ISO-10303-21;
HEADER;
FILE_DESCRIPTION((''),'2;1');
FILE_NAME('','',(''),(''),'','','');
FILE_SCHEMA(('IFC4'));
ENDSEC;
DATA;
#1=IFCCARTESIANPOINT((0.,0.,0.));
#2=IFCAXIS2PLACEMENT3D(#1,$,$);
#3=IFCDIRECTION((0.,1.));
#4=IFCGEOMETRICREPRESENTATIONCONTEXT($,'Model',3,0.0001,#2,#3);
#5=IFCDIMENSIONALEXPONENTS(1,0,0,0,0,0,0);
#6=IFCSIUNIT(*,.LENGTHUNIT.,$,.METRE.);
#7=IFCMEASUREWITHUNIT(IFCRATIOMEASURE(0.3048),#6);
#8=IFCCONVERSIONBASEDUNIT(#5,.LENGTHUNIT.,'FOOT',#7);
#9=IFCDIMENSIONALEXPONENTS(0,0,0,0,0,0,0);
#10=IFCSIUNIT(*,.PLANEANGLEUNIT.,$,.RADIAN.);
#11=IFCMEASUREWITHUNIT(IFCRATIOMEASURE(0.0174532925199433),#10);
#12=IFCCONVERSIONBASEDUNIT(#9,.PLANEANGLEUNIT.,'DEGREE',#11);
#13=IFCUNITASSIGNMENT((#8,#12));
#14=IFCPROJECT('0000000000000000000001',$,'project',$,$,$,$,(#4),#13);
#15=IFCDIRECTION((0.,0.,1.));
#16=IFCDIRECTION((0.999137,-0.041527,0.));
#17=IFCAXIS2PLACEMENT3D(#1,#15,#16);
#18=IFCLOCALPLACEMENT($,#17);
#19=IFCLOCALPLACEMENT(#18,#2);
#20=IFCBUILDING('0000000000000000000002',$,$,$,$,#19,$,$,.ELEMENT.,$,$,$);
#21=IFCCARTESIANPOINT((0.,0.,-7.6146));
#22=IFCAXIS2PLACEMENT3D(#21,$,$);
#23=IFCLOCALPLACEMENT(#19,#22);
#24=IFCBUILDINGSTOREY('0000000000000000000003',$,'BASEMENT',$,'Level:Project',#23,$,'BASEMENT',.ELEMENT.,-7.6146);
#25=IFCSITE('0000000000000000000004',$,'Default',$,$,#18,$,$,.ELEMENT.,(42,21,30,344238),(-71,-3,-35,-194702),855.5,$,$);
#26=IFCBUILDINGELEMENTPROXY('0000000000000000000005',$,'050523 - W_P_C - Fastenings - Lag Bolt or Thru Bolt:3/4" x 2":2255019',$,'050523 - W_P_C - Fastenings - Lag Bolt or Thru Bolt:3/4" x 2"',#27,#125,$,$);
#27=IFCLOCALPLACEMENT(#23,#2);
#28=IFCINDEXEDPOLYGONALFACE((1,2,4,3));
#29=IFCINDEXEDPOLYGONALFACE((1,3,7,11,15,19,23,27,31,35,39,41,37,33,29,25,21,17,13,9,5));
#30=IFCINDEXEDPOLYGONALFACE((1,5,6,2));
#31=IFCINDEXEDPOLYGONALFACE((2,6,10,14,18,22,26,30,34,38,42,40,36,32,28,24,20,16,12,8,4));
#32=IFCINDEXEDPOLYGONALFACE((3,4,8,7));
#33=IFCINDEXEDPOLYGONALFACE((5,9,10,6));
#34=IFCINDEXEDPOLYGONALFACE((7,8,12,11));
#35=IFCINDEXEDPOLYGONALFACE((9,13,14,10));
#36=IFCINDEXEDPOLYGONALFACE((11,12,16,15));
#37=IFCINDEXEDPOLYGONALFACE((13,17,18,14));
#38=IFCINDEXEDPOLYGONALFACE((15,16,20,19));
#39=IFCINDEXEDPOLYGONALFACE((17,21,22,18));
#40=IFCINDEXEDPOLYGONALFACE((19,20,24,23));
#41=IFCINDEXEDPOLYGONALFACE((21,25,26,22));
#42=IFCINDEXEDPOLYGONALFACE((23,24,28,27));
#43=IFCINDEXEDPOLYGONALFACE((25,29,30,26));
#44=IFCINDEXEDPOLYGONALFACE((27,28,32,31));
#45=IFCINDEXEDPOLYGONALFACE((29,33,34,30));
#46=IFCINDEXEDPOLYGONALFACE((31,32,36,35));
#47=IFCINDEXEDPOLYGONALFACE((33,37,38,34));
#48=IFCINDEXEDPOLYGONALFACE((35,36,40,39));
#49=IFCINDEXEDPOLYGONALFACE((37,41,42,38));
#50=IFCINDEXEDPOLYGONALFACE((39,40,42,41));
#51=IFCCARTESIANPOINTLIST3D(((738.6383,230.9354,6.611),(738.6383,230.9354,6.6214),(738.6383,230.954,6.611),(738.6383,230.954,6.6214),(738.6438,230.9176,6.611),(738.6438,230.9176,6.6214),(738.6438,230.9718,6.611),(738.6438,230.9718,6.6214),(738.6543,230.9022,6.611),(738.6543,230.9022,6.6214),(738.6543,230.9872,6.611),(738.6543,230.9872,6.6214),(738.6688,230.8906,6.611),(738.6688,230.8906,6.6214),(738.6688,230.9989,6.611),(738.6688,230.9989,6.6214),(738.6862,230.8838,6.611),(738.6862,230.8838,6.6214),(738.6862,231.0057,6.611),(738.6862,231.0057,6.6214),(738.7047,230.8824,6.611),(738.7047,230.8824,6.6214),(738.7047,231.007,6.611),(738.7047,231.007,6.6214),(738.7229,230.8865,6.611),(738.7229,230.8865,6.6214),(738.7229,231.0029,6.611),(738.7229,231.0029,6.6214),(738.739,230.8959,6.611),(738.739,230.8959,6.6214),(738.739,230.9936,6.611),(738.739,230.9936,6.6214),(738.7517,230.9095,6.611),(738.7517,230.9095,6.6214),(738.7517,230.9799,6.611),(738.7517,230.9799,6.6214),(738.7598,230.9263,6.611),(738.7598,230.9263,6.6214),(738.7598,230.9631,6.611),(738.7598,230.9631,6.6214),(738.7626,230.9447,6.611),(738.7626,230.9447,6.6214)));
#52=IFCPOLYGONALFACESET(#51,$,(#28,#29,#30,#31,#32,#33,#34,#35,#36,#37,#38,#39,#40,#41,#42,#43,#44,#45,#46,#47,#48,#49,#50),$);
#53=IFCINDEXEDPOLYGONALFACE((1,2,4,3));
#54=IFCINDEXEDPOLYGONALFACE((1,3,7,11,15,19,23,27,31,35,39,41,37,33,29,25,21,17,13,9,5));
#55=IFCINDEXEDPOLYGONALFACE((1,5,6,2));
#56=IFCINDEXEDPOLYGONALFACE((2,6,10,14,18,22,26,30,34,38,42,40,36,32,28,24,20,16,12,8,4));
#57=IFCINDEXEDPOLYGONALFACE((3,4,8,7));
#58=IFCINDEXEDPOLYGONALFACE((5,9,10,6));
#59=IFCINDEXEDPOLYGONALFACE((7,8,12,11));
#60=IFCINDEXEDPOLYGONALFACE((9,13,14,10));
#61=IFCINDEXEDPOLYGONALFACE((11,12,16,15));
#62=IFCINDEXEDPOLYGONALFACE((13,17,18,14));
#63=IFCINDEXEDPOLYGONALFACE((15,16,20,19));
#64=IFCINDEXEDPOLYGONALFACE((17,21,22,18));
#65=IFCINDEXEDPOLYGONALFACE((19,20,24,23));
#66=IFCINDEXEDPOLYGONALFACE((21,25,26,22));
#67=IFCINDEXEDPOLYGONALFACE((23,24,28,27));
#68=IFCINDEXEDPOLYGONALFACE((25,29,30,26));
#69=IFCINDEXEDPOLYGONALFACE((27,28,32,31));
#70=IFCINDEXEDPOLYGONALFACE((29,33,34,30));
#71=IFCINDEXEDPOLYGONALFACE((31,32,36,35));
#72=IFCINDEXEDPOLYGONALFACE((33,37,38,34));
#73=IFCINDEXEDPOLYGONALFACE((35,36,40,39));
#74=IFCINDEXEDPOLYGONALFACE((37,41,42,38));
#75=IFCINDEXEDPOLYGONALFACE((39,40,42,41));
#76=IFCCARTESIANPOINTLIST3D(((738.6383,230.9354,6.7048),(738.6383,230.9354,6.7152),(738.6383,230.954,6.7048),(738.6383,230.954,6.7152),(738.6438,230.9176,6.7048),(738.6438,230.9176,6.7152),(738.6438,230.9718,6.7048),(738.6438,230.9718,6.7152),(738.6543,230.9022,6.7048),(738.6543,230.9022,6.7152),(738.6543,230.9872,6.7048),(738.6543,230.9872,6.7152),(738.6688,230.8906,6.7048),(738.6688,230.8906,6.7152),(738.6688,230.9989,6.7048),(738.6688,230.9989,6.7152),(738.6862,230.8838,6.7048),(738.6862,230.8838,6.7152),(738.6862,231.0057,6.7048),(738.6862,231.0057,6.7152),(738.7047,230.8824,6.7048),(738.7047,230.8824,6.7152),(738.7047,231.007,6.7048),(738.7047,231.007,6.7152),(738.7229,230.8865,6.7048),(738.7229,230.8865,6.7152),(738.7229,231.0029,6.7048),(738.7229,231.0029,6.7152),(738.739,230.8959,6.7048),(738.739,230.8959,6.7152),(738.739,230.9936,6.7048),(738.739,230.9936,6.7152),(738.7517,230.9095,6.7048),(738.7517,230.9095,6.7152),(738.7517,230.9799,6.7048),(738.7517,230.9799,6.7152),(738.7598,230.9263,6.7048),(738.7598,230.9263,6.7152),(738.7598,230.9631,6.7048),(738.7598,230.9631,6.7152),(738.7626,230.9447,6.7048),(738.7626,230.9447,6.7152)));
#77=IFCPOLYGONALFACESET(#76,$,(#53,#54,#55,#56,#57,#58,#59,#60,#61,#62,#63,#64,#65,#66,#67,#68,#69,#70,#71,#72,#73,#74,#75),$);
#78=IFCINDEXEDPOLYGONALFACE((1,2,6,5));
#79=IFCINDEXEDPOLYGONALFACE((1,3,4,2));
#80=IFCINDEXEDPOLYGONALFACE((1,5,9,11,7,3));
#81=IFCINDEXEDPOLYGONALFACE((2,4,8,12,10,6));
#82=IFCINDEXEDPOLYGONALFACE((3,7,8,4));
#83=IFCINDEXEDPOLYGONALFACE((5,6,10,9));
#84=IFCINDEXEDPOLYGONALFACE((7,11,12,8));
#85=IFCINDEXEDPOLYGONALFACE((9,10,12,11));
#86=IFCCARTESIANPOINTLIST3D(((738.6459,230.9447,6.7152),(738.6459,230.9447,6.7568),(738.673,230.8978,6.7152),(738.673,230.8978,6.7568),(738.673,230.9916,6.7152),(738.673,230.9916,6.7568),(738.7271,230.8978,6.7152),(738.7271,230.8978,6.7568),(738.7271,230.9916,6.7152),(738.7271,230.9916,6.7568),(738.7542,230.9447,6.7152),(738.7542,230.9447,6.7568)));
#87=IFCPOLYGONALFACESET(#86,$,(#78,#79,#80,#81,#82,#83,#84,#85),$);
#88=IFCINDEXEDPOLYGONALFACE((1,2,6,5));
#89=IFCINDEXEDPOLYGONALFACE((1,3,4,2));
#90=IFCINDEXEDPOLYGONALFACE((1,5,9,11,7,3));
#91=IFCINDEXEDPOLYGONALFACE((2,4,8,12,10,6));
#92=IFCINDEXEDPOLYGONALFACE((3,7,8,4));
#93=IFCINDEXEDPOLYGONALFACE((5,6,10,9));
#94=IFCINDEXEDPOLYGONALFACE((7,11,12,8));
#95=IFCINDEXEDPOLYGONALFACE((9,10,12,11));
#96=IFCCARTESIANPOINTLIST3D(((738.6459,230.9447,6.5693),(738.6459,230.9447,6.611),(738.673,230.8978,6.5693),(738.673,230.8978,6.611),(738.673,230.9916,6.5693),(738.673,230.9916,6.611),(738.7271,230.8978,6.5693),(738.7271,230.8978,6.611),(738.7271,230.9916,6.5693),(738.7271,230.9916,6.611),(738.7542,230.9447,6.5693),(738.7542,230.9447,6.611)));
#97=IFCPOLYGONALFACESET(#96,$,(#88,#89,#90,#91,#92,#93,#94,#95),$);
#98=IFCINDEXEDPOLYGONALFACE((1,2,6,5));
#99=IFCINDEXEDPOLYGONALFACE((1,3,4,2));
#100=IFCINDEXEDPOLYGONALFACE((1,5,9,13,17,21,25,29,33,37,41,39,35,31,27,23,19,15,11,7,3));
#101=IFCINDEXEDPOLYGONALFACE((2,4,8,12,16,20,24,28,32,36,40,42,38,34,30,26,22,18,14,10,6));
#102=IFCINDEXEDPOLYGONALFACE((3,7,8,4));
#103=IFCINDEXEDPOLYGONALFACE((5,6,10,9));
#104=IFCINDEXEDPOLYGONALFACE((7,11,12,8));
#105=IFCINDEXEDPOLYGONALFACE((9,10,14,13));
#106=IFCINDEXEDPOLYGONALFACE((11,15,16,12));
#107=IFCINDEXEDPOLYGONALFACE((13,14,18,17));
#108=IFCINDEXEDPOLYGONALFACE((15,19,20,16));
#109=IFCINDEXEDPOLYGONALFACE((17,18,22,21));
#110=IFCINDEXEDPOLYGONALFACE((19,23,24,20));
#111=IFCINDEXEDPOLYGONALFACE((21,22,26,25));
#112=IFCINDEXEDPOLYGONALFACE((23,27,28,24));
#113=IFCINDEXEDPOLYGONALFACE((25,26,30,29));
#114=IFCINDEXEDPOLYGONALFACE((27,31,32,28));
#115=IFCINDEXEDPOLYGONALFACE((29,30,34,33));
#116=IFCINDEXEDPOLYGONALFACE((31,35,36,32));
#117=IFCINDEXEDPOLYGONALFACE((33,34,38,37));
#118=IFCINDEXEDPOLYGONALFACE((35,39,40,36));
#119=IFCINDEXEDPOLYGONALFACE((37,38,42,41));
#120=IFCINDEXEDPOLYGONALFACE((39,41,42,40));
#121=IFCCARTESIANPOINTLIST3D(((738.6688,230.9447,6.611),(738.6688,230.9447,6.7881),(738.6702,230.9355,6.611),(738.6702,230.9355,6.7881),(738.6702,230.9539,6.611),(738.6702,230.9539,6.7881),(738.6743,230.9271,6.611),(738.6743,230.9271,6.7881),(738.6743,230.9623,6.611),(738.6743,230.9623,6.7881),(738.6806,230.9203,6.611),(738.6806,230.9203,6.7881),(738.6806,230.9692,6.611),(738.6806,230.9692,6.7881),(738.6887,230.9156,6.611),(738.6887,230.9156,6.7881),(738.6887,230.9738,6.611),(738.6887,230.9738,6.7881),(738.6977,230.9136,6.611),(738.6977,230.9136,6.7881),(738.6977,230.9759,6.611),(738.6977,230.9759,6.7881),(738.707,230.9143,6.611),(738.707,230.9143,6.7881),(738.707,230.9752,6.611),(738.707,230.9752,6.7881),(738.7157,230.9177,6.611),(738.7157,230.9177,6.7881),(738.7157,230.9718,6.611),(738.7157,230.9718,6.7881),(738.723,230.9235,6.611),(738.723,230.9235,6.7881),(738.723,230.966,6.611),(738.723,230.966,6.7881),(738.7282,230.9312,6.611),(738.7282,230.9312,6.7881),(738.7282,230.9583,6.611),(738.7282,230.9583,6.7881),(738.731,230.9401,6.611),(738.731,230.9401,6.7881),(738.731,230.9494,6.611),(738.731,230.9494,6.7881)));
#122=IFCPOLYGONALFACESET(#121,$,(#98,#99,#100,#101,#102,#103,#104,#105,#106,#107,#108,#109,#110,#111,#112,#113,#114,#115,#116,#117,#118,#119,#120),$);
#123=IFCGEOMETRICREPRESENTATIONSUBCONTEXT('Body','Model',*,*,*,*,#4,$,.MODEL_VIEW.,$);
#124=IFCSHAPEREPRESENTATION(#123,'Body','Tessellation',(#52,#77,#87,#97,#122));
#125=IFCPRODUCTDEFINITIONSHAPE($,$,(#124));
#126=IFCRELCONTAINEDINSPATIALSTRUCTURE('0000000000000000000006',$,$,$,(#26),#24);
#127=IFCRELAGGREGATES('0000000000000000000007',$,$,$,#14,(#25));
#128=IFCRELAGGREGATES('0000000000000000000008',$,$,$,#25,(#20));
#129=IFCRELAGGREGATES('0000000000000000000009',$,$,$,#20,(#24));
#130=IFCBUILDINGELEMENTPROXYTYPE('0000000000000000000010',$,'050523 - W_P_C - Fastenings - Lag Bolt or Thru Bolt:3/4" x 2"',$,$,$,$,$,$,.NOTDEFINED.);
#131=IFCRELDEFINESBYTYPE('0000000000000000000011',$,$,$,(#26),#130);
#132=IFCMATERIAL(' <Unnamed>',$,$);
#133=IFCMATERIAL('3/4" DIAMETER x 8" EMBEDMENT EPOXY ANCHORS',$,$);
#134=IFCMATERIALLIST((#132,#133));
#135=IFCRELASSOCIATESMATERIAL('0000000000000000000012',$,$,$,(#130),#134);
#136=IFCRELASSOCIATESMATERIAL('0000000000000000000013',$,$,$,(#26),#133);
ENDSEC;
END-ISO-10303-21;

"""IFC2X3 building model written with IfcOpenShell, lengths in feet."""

from ifc_helpers import new_model, entity, si_unit, converted_unit, direction, frame, frame_2d, origin, place, context, subcontext, project, spatial, polyline, circle, outline, extrude, source, transform, mapped, material, material_list, type_object, type_shapes, element, save


model = new_model("IFC2X3")

# Units and contexts
model_context = context("Model", 3, precision=0.0001, world=origin(), true_north=direction((0.0, 1.0)))
body_context = subcontext(model_context, "Body", "Model", "MODEL_VIEW")
ifc_project = project(units=[converted_unit("LENGTHUNIT", "FOOT", entity("IfcRatioMeasure", 0.3048), si_unit("LENGTHUNIT", "METRE"), dimensions=[1, 0, 0, 0, 0, 0, 0]), converted_unit("PLANEANGLEUNIT", "DEGREE", entity("IfcRatioMeasure", 0.0174532925199433), si_unit("PLANEANGLEUNIT", "RADIAN"), dimensions=[0, 0, 0, 0, 0, 0, 0])], contexts=[model_context])

# Site, building, storey
site_placement = place(None, frame((0.0, 0.0, 0.0), z_axis=(0.0, 0.0, 1.0), x_axis=(0.999137, -0.041527, 0.0)))
site = spatial("IfcSite", under=ifc_project, at=site_placement, Name="Default", CompositionType="ELEMENT", RefLatitude=(42, 21, 30, 344238), RefLongitude=(-71, -3, -35, -194702), RefElevation=855.5)
building_placement = place(site_placement, origin())
building = spatial("IfcBuilding", under=site, at=building_placement, CompositionType="ELEMENT")
storey_placement = place(building_placement, frame((0.0, 0.0, -7.6146)))
storey = spatial("IfcBuildingStorey", under=building, at=storey_placement, Name="BASEMENT", ObjectType="Level:Project", LongName="BASEMENT", CompositionType="ELEMENT", Elevation=-7.6146)

# Building element proxy
ifc_material_1 = material(Name=" <Unnamed>")
ifc_material_2 = material(Name="3/4\" DIAMETER x 8\" EMBEDMENT EPOXY ANCHORS")
ifc_material_list_1 = material_list([ifc_material_1, ifc_material_2])
building_element_proxy_type_1 = type_object("IfcBuildingElementProxyType", Name="050523 - W_P_C - Fastenings - Lag Bolt or Thru Bolt:3/4\" x 2\"", PredefinedType="NOTDEFINED", material=ifc_material_list_1)
shared_shape_1 = source(origin(), body_context, "Body", "SweptSolid", [
    extrude(circle(Radius=0.0625, at=frame_2d((0.0, 0.0), x_axis=(1.0, 0.0))), frame((0.0, 0.0, 0.0), z_axis=(0.0, 0.0, 1.0), x_axis=(0.0, -1.0, 0.0)), (0.0, 0.0, 1.0), 0.0104),
    extrude(circle(Radius=0.0625, at=frame_2d((0.0, 0.0), x_axis=(1.0, 0.0))), frame((0.0, 0.0, -0.0938), z_axis=(0.0, 0.0, 1.0), x_axis=(0.0, -1.0, 0.0)), (0.0, 0.0, 1.0), 0.0104),
    extrude(outline(polyline([(-0.0271, -0.0469), (0.0271, -0.0469), (0.0541, 0.0), (0.0271, 0.0469), (-0.0271, 0.0469), (-0.0541, 0.0), (-0.0271, -0.0469)])), frame((0.0, 0.0, -0.1354), z_axis=(0.0, 0.0, 1.0), x_axis=(0.866025, -0.5, 0.0)), (0.0, 0.0, 1.0), 0.0417),
    extrude(outline(polyline([(-0.0271, -0.0469), (0.0271, -0.0469), (0.0541, 0.0), (0.0271, 0.0469), (-0.0271, 0.0469), (-0.0541, 0.0), (-0.0271, -0.0469)])), frame((0.0, 0.0, 0.0104), z_axis=(0.0, 0.0, 1.0), x_axis=(0.0, -1.0, 0.0)), (0.0, 0.0, 1.0), 0.0417),
    extrude(circle(Radius=0.0312, at=frame_2d((0.0, 0.0), x_axis=(1.0, 0.0))), frame((0.0, 0.0, -0.1667), z_axis=(0.0, 0.0, 1.0), x_axis=(0.0, 1.0, 0.0)), (0.0, 0.0, 1.0), 0.1771),
])
type_shapes(building_element_proxy_type_1, [shared_shape_1])
for number, where, z_axis, x_axis, name in (
    (1, (738.7001, 230.9447, 6.6214), (0.0, 0.0, -1.0), (0.0, -1.0, 0.0), "050523 - W_P_C - Fastenings - Lag Bolt or Thru Bolt:3/4\" x 2\":2255019"),
):
    element("IfcBuildingElementProxy", number, at=place(storey_placement, frame(where, z_axis=z_axis, x_axis=x_axis)), inside=storey, type_object=building_element_proxy_type_1, material=ifc_material_2, Name=name, ObjectType="050523 - W_P_C - Fastenings - Lag Bolt or Thru Bolt:3/4\" x 2\"", context=body_context, shape_type="MappedRepresentation", body=[
        mapped(shared_shape_1, transform((0.0, 0.0, 0.0), scale=1.0)),
    ])

save(model, "model.ifc")
